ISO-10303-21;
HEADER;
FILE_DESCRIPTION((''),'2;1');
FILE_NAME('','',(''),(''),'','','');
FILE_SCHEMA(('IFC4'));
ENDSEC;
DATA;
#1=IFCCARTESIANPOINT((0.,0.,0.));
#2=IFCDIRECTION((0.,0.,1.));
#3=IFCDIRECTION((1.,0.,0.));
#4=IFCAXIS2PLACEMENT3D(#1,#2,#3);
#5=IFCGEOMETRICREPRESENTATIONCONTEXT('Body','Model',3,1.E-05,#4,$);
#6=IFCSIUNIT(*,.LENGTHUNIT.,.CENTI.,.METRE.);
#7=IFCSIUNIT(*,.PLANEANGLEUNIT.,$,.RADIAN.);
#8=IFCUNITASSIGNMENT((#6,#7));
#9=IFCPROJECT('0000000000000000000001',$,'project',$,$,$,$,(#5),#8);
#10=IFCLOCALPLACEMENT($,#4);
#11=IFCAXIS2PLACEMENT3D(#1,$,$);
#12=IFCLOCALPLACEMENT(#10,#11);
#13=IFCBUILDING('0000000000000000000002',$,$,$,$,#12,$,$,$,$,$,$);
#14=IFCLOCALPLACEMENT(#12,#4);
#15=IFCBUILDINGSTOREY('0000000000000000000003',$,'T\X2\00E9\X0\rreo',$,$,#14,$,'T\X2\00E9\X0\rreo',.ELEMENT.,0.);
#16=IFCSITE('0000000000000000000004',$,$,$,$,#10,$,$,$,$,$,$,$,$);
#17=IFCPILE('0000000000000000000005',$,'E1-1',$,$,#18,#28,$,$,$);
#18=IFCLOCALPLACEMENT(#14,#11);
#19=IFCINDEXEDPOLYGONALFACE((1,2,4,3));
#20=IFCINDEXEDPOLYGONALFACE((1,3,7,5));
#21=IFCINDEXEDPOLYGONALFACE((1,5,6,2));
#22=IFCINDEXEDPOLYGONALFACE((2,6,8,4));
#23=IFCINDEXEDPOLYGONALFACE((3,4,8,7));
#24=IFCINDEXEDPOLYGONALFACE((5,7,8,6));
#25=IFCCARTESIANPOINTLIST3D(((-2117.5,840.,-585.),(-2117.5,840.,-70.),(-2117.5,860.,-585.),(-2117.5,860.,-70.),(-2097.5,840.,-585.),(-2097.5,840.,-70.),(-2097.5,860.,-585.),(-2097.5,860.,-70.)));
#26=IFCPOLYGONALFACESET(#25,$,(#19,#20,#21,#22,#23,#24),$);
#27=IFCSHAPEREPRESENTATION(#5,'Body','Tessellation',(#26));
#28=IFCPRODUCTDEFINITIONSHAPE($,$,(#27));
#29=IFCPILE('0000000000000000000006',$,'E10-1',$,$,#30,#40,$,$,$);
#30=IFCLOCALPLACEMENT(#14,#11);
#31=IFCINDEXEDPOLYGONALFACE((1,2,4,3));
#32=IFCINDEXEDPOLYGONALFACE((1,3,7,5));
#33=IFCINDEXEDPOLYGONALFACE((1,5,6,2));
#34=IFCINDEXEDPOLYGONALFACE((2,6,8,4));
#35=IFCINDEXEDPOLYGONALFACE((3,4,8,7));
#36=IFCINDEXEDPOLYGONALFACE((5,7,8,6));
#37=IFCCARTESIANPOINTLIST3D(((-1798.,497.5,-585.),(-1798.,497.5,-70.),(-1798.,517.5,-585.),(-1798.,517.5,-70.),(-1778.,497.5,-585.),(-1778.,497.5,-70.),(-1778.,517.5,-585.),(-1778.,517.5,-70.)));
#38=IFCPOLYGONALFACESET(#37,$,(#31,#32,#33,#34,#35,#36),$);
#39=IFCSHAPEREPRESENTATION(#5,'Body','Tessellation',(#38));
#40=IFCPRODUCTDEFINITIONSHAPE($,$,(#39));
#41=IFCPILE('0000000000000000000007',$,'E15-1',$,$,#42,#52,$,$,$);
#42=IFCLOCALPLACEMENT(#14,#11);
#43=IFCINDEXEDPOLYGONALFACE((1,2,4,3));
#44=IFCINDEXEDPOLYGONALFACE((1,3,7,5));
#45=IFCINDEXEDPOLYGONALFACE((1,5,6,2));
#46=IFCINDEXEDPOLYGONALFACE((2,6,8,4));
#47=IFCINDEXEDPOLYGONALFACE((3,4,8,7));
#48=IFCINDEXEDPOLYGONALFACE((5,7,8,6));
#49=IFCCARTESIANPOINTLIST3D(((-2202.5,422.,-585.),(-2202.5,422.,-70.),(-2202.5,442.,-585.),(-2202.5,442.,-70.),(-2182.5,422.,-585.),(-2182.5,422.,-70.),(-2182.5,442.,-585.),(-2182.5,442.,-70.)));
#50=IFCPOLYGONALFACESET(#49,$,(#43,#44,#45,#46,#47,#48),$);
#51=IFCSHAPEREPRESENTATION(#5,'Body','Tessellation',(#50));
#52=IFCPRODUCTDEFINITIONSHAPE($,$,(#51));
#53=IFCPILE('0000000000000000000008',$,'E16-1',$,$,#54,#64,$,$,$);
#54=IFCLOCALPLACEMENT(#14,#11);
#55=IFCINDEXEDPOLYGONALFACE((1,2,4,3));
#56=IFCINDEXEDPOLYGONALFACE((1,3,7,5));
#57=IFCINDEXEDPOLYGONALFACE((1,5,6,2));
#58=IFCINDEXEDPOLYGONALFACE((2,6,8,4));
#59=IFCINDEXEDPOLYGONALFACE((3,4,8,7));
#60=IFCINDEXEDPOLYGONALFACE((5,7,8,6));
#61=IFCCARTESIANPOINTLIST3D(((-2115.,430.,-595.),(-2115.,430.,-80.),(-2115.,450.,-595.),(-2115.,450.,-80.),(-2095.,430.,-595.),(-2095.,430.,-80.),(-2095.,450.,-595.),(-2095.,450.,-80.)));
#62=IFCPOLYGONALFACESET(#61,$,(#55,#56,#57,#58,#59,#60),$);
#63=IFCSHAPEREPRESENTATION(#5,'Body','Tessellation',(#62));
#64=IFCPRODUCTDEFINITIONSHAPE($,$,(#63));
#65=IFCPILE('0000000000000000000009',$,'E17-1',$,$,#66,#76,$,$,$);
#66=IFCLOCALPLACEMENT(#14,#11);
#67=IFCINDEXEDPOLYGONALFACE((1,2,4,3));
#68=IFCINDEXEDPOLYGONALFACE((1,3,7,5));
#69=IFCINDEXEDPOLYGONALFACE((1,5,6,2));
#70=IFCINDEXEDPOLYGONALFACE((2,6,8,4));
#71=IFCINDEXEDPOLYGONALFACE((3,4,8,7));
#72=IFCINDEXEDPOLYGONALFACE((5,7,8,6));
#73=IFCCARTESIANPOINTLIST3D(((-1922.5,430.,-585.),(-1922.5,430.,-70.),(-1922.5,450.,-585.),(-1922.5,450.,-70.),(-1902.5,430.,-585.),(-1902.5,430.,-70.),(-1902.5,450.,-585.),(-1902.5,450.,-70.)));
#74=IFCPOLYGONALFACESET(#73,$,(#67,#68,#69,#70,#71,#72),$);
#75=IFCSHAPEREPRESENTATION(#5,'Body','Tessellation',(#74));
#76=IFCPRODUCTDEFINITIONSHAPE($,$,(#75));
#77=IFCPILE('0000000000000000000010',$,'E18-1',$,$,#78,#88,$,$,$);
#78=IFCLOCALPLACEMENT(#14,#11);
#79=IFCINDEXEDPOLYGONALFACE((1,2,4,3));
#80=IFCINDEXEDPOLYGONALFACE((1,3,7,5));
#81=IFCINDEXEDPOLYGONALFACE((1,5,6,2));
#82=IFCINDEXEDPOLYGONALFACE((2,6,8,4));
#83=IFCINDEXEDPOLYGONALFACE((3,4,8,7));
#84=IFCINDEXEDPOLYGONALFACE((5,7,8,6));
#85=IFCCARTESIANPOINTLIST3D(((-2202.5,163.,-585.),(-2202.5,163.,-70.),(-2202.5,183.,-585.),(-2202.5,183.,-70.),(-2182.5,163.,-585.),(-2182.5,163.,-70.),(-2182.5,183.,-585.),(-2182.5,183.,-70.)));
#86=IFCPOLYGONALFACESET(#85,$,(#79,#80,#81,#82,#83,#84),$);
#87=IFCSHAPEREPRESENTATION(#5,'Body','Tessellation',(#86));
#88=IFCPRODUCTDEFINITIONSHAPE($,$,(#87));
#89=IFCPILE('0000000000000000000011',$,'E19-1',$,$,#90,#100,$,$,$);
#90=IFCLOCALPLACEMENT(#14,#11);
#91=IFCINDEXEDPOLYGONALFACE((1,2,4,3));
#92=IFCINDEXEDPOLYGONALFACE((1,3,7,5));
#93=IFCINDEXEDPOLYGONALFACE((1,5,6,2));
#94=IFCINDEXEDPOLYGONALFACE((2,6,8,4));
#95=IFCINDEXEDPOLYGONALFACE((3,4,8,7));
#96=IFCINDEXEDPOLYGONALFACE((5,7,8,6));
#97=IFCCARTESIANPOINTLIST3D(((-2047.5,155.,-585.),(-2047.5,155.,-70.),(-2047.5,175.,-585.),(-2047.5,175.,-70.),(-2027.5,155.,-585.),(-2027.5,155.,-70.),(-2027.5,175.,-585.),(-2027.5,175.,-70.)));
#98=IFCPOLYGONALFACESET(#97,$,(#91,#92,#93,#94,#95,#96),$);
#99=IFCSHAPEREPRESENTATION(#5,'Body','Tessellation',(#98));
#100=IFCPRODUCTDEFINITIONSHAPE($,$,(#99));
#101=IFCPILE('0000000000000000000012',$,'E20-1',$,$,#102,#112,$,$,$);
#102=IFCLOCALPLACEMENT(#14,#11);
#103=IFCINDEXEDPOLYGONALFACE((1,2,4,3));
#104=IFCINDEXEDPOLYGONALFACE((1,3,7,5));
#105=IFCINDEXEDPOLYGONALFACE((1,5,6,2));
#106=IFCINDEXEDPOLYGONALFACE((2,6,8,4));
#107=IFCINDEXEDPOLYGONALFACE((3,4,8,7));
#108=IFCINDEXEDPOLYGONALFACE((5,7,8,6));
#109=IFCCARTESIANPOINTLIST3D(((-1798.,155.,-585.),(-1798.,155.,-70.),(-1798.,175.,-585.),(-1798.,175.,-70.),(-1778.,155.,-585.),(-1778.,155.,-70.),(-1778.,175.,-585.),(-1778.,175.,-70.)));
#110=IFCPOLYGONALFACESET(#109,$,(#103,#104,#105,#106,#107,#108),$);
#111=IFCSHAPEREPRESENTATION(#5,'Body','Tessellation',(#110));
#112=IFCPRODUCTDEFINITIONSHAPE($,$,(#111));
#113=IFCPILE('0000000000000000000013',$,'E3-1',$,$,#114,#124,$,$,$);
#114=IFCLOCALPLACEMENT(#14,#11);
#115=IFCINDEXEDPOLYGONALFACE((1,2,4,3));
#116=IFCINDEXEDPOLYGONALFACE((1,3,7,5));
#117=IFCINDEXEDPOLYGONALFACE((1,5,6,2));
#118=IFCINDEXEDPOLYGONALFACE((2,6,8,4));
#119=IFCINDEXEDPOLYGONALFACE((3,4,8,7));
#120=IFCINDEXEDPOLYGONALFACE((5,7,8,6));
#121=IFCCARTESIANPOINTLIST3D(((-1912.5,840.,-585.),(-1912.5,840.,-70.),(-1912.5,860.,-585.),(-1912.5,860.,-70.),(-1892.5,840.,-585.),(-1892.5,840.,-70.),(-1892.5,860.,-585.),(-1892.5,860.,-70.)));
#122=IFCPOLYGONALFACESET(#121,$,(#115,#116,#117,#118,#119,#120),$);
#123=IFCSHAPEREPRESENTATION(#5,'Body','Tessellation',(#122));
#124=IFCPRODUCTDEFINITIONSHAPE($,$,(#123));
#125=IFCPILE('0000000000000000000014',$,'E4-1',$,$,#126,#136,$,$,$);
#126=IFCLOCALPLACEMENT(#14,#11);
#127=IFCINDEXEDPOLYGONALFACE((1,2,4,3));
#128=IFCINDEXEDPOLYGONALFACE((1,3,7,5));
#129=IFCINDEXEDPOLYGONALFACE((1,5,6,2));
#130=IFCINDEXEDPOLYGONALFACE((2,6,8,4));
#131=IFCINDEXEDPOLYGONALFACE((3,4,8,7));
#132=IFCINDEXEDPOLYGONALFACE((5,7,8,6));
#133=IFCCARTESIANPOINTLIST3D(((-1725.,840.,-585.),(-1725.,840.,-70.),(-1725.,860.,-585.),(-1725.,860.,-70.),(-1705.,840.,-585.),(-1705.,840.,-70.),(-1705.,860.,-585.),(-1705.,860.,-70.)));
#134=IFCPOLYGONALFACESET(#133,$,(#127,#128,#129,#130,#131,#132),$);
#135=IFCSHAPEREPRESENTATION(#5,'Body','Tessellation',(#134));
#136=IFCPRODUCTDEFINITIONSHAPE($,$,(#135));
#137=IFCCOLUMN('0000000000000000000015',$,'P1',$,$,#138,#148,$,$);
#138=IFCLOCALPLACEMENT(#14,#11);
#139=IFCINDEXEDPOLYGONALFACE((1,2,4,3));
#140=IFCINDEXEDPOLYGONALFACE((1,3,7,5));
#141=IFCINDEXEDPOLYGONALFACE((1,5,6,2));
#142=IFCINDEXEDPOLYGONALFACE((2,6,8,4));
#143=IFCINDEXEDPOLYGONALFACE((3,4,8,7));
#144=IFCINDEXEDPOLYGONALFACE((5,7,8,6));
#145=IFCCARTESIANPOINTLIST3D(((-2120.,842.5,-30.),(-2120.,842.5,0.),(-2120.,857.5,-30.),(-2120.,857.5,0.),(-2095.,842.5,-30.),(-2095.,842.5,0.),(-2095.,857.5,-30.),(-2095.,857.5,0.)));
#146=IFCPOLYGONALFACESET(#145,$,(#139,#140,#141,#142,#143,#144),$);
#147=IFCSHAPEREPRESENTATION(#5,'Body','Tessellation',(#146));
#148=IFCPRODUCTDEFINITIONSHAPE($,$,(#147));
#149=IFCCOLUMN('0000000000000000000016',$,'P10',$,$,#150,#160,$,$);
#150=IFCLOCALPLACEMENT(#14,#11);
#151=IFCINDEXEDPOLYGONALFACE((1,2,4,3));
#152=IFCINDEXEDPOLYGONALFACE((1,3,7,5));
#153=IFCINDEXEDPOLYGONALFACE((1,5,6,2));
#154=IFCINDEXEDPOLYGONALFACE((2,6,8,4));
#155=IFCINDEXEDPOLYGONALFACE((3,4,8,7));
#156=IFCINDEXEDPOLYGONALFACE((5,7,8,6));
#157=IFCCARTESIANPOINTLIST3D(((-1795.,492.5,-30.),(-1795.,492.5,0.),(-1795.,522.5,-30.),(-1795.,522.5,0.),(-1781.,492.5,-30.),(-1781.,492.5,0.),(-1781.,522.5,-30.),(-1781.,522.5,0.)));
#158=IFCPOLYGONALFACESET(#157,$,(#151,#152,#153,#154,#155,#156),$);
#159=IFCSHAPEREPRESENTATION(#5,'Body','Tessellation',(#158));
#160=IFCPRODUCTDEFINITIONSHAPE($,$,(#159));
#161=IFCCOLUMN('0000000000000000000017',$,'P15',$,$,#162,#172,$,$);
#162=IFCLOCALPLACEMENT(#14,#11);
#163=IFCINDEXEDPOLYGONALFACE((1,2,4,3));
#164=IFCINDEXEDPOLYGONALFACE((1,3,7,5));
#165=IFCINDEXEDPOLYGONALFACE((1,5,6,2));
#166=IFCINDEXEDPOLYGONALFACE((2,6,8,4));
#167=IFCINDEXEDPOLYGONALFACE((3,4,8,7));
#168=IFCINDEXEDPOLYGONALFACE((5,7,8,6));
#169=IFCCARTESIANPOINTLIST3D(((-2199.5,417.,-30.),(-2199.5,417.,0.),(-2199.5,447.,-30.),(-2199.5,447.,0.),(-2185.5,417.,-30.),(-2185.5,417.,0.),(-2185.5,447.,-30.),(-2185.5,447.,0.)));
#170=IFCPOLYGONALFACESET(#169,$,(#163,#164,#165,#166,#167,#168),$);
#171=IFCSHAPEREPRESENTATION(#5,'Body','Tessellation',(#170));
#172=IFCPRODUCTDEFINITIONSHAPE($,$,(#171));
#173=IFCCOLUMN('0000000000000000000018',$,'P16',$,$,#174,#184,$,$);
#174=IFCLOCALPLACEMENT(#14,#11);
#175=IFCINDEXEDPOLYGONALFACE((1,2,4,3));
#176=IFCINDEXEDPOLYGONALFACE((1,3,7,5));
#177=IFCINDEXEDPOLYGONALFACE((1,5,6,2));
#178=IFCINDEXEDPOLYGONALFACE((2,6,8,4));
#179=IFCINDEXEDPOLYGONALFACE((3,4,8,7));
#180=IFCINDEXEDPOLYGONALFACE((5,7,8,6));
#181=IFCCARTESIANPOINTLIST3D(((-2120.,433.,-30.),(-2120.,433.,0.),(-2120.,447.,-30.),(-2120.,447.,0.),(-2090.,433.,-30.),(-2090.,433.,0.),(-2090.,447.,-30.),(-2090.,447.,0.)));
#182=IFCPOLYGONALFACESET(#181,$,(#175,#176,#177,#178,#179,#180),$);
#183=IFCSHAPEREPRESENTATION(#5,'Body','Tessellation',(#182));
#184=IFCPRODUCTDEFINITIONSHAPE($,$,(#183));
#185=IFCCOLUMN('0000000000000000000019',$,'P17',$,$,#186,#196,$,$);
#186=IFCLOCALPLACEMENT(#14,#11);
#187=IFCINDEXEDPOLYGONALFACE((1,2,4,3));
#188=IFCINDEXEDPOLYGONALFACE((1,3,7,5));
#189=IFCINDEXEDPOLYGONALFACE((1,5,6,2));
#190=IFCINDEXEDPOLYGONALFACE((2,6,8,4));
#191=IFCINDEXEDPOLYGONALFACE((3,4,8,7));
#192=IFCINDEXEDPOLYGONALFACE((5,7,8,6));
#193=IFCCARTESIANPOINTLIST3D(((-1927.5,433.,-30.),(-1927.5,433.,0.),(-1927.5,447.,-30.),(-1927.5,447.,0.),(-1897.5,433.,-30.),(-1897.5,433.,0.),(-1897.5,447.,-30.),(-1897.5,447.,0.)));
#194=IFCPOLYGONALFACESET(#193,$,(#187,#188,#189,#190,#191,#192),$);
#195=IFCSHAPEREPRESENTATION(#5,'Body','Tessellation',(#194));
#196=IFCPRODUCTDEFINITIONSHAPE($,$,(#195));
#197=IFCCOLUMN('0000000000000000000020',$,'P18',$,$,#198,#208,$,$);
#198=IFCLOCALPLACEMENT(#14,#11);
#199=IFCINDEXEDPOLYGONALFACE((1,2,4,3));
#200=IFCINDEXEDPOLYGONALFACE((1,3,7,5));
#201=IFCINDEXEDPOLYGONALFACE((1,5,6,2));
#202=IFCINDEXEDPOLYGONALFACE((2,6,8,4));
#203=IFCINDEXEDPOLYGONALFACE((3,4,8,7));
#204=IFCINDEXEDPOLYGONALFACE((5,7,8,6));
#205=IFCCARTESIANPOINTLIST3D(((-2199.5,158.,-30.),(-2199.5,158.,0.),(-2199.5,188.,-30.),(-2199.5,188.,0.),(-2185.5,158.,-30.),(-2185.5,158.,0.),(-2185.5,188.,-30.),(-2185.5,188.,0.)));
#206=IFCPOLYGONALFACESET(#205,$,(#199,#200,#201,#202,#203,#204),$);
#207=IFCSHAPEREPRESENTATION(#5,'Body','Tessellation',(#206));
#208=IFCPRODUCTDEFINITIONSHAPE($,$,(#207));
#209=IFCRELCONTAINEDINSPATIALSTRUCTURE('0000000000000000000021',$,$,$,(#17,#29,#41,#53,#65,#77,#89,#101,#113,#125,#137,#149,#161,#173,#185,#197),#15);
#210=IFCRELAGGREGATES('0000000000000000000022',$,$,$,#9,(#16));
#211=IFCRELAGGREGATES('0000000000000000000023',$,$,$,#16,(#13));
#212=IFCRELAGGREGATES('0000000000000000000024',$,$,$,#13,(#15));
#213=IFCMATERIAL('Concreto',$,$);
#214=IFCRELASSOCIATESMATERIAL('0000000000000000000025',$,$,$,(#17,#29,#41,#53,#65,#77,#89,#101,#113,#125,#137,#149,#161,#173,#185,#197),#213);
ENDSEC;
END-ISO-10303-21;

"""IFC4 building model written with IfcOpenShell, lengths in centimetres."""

from ifc_helpers import new_model, si_unit, frame, origin, origin_with_axes, origin_2d_with_axis, place, context, project, spatial, rectangle, extrude, material, element, save


model = new_model("IFC4")

# Units and contexts
model_context = context("Model", 3, precision=1e-05, world=origin_with_axes(), identifier="Body")
ifc_project = project(units=[si_unit("LENGTHUNIT", "METRE", prefix="CENTI"), si_unit("PLANEANGLEUNIT", "RADIAN")], contexts=[model_context])

# Site, building, storey
site_placement = place(None, origin_with_axes())
site = spatial("IfcSite", under=ifc_project, at=site_placement)
building_placement = place(site_placement, origin())
building = spatial("IfcBuilding", under=site, at=building_placement)
storey_placement = place(building_placement, origin_with_axes())
storey = spatial("IfcBuildingStorey", under=building, at=storey_placement, Name="Térreo", LongName="Térreo", CompositionType="ELEMENT", Elevation=0.0)

# Piles
ifc_material = material(Name="Concreto")
pile_1_placement = place(storey_placement, frame((-2107.5, 850.0, -70.0), z_axis=(0.0, 0.0, 1.0), x_axis=(1.0, 0.0, 0.0)))
element("IfcPile", 1, at=pile_1_placement, inside=storey, material=ifc_material, Name="E1-1", context=model_context, shape_type="SweptSolid", body=[
    extrude(rectangle(XDim=20.0, YDim=20.0, at=origin_2d_with_axis()), frame((0.0, 0.0, -515.0), z_axis=(0.0, 0.0, 1.0), x_axis=(0.0, 1.0, 0.0)), (0.0, 0.0, 1.0), 515.0),
])
pile_2_placement = place(storey_placement, frame((-1788.0, 507.5, -70.0), z_axis=(0.0, 0.0, 1.0), x_axis=(1.0, 0.0, 0.0)))
element("IfcPile", 2, at=pile_2_placement, inside=storey, material=ifc_material, Name="E10-1", context=model_context, shape_type="SweptSolid", body=[
    extrude(rectangle(XDim=20.0, YDim=20.0, at=origin_2d_with_axis()), frame((0.0, 0.0, -515.0), z_axis=(0.0, 0.0, 1.0), x_axis=(1.0, 0.0, 0.0)), (0.0, 0.0, 1.0), 515.0),
])
pile_3_placement = place(storey_placement, frame((-2192.5, 432.0, -70.0), z_axis=(0.0, 0.0, 1.0), x_axis=(1.0, 0.0, 0.0)))
element("IfcPile", 3, at=pile_3_placement, inside=storey, material=ifc_material, Name="E15-1", context=model_context, shape_type="SweptSolid", body=[
    extrude(rectangle(XDim=20.0, YDim=20.0, at=origin_2d_with_axis()), frame((0.0, 0.0, -515.0), z_axis=(0.0, 0.0, 1.0), x_axis=(-1.0, 0.0, 0.0)), (0.0, 0.0, 1.0), 515.0),
])
for number, where, z_axis, x_axis, name in (
    (4, (-2105.0, 440.0, -80.0), (0.0, 0.0, 1.0), (1.0, 0.0, 0.0), "E16-1"),
    (5, (-1912.5, 440.0, -70.0), (0.0, 0.0, 1.0), (1.0, 0.0, 0.0), "E17-1"),
):
    element("IfcPile", number, at=place(storey_placement, frame(where, z_axis=z_axis, x_axis=x_axis)), inside=storey, material=ifc_material, Name=name, context=model_context, shape_type="SweptSolid", body=[
        extrude(rectangle(XDim=20.0, YDim=20.0, at=origin_2d_with_axis()), frame((0.0, 0.0, -515.0), z_axis=(0.0, 0.0, 1.0), x_axis=(0.0, 1.0, 0.0)), (0.0, 0.0, 1.0), 515.0),
    ])
pile_4_placement = place(storey_placement, frame((-2192.5, 173.0, -70.0), z_axis=(0.0, 0.0, 1.0), x_axis=(1.0, 0.0, 0.0)))
element("IfcPile", 6, at=pile_4_placement, inside=storey, material=ifc_material, Name="E18-1", context=model_context, shape_type="SweptSolid", body=[
    extrude(rectangle(XDim=20.0, YDim=20.0, at=origin_2d_with_axis()), frame((0.0, 0.0, -515.0), z_axis=(0.0, 0.0, 1.0), x_axis=(1.0, 0.0, 0.0)), (0.0, 0.0, 1.0), 515.0),
])
pile_5_placement = place(storey_placement, frame((-2037.5, 165.0, -70.0), z_axis=(0.0, 0.0, 1.0), x_axis=(1.0, 0.0, 0.0)))
element("IfcPile", 7, at=pile_5_placement, inside=storey, material=ifc_material, Name="E19-1", context=model_context, shape_type="SweptSolid", body=[
    extrude(rectangle(XDim=20.0, YDim=20.0, at=origin_2d_with_axis()), frame((0.0, 0.0, -515.0), z_axis=(0.0, 0.0, 1.0), x_axis=(0.0, 1.0, 0.0)), (0.0, 0.0, 1.0), 515.0),
])
pile_6_placement = place(storey_placement, frame((-1788.0, 165.0, -70.0), z_axis=(0.0, 0.0, 1.0), x_axis=(1.0, 0.0, 0.0)))
element("IfcPile", 8, at=pile_6_placement, inside=storey, material=ifc_material, Name="E20-1", context=model_context, shape_type="SweptSolid", body=[
    extrude(rectangle(XDim=20.0, YDim=20.0, at=origin_2d_with_axis()), frame((0.0, 0.0, -515.0), z_axis=(0.0, 0.0, 1.0), x_axis=(0.0, -1.0, 0.0)), (0.0, 0.0, 1.0), 515.0),
])
for number, where, z_axis, x_axis, name in (
    (9, (-1902.5, 850.0, -70.0), (0.0, 0.0, 1.0), (1.0, 0.0, 0.0), "E3-1"),
    (10, (-1715.0, 850.0, -70.0), (0.0, 0.0, 1.0), (1.0, 0.0, 0.0), "E4-1"),
):
    element("IfcPile", number, at=place(storey_placement, frame(where, z_axis=z_axis, x_axis=x_axis)), inside=storey, material=ifc_material, Name=name, context=model_context, shape_type="SweptSolid", body=[
        extrude(rectangle(XDim=20.0, YDim=20.0, at=origin_2d_with_axis()), frame((0.0, 0.0, -515.0), z_axis=(0.0, 0.0, 1.0), x_axis=(0.0, 1.0, 0.0)), (0.0, 0.0, 1.0), 515.0),
    ])

# Columns
column_1_placement = place(storey_placement, frame((-2107.5, 850.0, 0.0), z_axis=(0.0, 0.0, 1.0), x_axis=(1.0, 0.0, 0.0)))
element("IfcColumn", 11, at=column_1_placement, inside=storey, material=ifc_material, Name="P1", context=model_context, shape_type="SolidModel", body=[
    extrude(rectangle(XDim=15.0, YDim=25.0, at=origin_2d_with_axis()), frame((0.0, 0.0, -30.0), z_axis=(0.0, 0.0, 1.0), x_axis=(0.0, 1.0, 0.0)), (0.0, 0.0, 1.0), 30.0),
])
column_2_placement = place(storey_placement, frame((-1788.0, 507.5, 0.0), z_axis=(0.0, 0.0, 1.0), x_axis=(1.0, 0.0, 0.0)))
element("IfcColumn", 12, at=column_2_placement, inside=storey, material=ifc_material, Name="P10", context=model_context, shape_type="SolidModel", body=[
    extrude(rectangle(XDim=14.0, YDim=30.0, at=origin_2d_with_axis()), frame((0.0, 0.0, -30.0), z_axis=(0.0, 0.0, 1.0), x_axis=(1.0, 0.0, 0.0)), (0.0, 0.0, 1.0), 30.0),
])
column_3_placement = place(storey_placement, frame((-2192.5, 432.0, 0.0), z_axis=(0.0, 0.0, 1.0), x_axis=(1.0, 0.0, 0.0)))
element("IfcColumn", 13, at=column_3_placement, inside=storey, material=ifc_material, Name="P15", context=model_context, shape_type="SolidModel", body=[
    extrude(rectangle(XDim=14.0, YDim=30.0, at=origin_2d_with_axis()), frame((0.0, 0.0, -30.0), z_axis=(0.0, 0.0, 1.0), x_axis=(-1.0, 0.0, 0.0)), (0.0, 0.0, 1.0), 30.0),
])
for number, where, z_axis, x_axis, name in (
    (14, (-2105.0, 440.0, 0.0), (0.0, 0.0, 1.0), (1.0, 0.0, 0.0), "P16"),
    (15, (-1912.5, 440.0, 0.0), (0.0, 0.0, 1.0), (1.0, 0.0, 0.0), "P17"),
):
    element("IfcColumn", number, at=place(storey_placement, frame(where, z_axis=z_axis, x_axis=x_axis)), inside=storey, material=ifc_material, Name=name, context=model_context, shape_type="SolidModel", body=[
        extrude(rectangle(XDim=14.0, YDim=30.0, at=origin_2d_with_axis()), frame((0.0, 0.0, -30.0), z_axis=(0.0, 0.0, 1.0), x_axis=(0.0, 1.0, 0.0)), (0.0, 0.0, 1.0), 30.0),
    ])
column_4_placement = place(storey_placement, frame((-2192.5, 173.0, 0.0), z_axis=(0.0, 0.0, 1.0), x_axis=(1.0, 0.0, 0.0)))
element("IfcColumn", 16, at=column_4_placement, inside=storey, material=ifc_material, Name="P18", context=model_context, shape_type="SolidModel", body=[
    extrude(rectangle(XDim=14.0, YDim=30.0, at=origin_2d_with_axis()), frame((0.0, 0.0, -30.0), z_axis=(0.0, 0.0, 1.0), x_axis=(1.0, 0.0, 0.0)), (0.0, 0.0, 1.0), 30.0),
])

save(model, "model.ifc")
